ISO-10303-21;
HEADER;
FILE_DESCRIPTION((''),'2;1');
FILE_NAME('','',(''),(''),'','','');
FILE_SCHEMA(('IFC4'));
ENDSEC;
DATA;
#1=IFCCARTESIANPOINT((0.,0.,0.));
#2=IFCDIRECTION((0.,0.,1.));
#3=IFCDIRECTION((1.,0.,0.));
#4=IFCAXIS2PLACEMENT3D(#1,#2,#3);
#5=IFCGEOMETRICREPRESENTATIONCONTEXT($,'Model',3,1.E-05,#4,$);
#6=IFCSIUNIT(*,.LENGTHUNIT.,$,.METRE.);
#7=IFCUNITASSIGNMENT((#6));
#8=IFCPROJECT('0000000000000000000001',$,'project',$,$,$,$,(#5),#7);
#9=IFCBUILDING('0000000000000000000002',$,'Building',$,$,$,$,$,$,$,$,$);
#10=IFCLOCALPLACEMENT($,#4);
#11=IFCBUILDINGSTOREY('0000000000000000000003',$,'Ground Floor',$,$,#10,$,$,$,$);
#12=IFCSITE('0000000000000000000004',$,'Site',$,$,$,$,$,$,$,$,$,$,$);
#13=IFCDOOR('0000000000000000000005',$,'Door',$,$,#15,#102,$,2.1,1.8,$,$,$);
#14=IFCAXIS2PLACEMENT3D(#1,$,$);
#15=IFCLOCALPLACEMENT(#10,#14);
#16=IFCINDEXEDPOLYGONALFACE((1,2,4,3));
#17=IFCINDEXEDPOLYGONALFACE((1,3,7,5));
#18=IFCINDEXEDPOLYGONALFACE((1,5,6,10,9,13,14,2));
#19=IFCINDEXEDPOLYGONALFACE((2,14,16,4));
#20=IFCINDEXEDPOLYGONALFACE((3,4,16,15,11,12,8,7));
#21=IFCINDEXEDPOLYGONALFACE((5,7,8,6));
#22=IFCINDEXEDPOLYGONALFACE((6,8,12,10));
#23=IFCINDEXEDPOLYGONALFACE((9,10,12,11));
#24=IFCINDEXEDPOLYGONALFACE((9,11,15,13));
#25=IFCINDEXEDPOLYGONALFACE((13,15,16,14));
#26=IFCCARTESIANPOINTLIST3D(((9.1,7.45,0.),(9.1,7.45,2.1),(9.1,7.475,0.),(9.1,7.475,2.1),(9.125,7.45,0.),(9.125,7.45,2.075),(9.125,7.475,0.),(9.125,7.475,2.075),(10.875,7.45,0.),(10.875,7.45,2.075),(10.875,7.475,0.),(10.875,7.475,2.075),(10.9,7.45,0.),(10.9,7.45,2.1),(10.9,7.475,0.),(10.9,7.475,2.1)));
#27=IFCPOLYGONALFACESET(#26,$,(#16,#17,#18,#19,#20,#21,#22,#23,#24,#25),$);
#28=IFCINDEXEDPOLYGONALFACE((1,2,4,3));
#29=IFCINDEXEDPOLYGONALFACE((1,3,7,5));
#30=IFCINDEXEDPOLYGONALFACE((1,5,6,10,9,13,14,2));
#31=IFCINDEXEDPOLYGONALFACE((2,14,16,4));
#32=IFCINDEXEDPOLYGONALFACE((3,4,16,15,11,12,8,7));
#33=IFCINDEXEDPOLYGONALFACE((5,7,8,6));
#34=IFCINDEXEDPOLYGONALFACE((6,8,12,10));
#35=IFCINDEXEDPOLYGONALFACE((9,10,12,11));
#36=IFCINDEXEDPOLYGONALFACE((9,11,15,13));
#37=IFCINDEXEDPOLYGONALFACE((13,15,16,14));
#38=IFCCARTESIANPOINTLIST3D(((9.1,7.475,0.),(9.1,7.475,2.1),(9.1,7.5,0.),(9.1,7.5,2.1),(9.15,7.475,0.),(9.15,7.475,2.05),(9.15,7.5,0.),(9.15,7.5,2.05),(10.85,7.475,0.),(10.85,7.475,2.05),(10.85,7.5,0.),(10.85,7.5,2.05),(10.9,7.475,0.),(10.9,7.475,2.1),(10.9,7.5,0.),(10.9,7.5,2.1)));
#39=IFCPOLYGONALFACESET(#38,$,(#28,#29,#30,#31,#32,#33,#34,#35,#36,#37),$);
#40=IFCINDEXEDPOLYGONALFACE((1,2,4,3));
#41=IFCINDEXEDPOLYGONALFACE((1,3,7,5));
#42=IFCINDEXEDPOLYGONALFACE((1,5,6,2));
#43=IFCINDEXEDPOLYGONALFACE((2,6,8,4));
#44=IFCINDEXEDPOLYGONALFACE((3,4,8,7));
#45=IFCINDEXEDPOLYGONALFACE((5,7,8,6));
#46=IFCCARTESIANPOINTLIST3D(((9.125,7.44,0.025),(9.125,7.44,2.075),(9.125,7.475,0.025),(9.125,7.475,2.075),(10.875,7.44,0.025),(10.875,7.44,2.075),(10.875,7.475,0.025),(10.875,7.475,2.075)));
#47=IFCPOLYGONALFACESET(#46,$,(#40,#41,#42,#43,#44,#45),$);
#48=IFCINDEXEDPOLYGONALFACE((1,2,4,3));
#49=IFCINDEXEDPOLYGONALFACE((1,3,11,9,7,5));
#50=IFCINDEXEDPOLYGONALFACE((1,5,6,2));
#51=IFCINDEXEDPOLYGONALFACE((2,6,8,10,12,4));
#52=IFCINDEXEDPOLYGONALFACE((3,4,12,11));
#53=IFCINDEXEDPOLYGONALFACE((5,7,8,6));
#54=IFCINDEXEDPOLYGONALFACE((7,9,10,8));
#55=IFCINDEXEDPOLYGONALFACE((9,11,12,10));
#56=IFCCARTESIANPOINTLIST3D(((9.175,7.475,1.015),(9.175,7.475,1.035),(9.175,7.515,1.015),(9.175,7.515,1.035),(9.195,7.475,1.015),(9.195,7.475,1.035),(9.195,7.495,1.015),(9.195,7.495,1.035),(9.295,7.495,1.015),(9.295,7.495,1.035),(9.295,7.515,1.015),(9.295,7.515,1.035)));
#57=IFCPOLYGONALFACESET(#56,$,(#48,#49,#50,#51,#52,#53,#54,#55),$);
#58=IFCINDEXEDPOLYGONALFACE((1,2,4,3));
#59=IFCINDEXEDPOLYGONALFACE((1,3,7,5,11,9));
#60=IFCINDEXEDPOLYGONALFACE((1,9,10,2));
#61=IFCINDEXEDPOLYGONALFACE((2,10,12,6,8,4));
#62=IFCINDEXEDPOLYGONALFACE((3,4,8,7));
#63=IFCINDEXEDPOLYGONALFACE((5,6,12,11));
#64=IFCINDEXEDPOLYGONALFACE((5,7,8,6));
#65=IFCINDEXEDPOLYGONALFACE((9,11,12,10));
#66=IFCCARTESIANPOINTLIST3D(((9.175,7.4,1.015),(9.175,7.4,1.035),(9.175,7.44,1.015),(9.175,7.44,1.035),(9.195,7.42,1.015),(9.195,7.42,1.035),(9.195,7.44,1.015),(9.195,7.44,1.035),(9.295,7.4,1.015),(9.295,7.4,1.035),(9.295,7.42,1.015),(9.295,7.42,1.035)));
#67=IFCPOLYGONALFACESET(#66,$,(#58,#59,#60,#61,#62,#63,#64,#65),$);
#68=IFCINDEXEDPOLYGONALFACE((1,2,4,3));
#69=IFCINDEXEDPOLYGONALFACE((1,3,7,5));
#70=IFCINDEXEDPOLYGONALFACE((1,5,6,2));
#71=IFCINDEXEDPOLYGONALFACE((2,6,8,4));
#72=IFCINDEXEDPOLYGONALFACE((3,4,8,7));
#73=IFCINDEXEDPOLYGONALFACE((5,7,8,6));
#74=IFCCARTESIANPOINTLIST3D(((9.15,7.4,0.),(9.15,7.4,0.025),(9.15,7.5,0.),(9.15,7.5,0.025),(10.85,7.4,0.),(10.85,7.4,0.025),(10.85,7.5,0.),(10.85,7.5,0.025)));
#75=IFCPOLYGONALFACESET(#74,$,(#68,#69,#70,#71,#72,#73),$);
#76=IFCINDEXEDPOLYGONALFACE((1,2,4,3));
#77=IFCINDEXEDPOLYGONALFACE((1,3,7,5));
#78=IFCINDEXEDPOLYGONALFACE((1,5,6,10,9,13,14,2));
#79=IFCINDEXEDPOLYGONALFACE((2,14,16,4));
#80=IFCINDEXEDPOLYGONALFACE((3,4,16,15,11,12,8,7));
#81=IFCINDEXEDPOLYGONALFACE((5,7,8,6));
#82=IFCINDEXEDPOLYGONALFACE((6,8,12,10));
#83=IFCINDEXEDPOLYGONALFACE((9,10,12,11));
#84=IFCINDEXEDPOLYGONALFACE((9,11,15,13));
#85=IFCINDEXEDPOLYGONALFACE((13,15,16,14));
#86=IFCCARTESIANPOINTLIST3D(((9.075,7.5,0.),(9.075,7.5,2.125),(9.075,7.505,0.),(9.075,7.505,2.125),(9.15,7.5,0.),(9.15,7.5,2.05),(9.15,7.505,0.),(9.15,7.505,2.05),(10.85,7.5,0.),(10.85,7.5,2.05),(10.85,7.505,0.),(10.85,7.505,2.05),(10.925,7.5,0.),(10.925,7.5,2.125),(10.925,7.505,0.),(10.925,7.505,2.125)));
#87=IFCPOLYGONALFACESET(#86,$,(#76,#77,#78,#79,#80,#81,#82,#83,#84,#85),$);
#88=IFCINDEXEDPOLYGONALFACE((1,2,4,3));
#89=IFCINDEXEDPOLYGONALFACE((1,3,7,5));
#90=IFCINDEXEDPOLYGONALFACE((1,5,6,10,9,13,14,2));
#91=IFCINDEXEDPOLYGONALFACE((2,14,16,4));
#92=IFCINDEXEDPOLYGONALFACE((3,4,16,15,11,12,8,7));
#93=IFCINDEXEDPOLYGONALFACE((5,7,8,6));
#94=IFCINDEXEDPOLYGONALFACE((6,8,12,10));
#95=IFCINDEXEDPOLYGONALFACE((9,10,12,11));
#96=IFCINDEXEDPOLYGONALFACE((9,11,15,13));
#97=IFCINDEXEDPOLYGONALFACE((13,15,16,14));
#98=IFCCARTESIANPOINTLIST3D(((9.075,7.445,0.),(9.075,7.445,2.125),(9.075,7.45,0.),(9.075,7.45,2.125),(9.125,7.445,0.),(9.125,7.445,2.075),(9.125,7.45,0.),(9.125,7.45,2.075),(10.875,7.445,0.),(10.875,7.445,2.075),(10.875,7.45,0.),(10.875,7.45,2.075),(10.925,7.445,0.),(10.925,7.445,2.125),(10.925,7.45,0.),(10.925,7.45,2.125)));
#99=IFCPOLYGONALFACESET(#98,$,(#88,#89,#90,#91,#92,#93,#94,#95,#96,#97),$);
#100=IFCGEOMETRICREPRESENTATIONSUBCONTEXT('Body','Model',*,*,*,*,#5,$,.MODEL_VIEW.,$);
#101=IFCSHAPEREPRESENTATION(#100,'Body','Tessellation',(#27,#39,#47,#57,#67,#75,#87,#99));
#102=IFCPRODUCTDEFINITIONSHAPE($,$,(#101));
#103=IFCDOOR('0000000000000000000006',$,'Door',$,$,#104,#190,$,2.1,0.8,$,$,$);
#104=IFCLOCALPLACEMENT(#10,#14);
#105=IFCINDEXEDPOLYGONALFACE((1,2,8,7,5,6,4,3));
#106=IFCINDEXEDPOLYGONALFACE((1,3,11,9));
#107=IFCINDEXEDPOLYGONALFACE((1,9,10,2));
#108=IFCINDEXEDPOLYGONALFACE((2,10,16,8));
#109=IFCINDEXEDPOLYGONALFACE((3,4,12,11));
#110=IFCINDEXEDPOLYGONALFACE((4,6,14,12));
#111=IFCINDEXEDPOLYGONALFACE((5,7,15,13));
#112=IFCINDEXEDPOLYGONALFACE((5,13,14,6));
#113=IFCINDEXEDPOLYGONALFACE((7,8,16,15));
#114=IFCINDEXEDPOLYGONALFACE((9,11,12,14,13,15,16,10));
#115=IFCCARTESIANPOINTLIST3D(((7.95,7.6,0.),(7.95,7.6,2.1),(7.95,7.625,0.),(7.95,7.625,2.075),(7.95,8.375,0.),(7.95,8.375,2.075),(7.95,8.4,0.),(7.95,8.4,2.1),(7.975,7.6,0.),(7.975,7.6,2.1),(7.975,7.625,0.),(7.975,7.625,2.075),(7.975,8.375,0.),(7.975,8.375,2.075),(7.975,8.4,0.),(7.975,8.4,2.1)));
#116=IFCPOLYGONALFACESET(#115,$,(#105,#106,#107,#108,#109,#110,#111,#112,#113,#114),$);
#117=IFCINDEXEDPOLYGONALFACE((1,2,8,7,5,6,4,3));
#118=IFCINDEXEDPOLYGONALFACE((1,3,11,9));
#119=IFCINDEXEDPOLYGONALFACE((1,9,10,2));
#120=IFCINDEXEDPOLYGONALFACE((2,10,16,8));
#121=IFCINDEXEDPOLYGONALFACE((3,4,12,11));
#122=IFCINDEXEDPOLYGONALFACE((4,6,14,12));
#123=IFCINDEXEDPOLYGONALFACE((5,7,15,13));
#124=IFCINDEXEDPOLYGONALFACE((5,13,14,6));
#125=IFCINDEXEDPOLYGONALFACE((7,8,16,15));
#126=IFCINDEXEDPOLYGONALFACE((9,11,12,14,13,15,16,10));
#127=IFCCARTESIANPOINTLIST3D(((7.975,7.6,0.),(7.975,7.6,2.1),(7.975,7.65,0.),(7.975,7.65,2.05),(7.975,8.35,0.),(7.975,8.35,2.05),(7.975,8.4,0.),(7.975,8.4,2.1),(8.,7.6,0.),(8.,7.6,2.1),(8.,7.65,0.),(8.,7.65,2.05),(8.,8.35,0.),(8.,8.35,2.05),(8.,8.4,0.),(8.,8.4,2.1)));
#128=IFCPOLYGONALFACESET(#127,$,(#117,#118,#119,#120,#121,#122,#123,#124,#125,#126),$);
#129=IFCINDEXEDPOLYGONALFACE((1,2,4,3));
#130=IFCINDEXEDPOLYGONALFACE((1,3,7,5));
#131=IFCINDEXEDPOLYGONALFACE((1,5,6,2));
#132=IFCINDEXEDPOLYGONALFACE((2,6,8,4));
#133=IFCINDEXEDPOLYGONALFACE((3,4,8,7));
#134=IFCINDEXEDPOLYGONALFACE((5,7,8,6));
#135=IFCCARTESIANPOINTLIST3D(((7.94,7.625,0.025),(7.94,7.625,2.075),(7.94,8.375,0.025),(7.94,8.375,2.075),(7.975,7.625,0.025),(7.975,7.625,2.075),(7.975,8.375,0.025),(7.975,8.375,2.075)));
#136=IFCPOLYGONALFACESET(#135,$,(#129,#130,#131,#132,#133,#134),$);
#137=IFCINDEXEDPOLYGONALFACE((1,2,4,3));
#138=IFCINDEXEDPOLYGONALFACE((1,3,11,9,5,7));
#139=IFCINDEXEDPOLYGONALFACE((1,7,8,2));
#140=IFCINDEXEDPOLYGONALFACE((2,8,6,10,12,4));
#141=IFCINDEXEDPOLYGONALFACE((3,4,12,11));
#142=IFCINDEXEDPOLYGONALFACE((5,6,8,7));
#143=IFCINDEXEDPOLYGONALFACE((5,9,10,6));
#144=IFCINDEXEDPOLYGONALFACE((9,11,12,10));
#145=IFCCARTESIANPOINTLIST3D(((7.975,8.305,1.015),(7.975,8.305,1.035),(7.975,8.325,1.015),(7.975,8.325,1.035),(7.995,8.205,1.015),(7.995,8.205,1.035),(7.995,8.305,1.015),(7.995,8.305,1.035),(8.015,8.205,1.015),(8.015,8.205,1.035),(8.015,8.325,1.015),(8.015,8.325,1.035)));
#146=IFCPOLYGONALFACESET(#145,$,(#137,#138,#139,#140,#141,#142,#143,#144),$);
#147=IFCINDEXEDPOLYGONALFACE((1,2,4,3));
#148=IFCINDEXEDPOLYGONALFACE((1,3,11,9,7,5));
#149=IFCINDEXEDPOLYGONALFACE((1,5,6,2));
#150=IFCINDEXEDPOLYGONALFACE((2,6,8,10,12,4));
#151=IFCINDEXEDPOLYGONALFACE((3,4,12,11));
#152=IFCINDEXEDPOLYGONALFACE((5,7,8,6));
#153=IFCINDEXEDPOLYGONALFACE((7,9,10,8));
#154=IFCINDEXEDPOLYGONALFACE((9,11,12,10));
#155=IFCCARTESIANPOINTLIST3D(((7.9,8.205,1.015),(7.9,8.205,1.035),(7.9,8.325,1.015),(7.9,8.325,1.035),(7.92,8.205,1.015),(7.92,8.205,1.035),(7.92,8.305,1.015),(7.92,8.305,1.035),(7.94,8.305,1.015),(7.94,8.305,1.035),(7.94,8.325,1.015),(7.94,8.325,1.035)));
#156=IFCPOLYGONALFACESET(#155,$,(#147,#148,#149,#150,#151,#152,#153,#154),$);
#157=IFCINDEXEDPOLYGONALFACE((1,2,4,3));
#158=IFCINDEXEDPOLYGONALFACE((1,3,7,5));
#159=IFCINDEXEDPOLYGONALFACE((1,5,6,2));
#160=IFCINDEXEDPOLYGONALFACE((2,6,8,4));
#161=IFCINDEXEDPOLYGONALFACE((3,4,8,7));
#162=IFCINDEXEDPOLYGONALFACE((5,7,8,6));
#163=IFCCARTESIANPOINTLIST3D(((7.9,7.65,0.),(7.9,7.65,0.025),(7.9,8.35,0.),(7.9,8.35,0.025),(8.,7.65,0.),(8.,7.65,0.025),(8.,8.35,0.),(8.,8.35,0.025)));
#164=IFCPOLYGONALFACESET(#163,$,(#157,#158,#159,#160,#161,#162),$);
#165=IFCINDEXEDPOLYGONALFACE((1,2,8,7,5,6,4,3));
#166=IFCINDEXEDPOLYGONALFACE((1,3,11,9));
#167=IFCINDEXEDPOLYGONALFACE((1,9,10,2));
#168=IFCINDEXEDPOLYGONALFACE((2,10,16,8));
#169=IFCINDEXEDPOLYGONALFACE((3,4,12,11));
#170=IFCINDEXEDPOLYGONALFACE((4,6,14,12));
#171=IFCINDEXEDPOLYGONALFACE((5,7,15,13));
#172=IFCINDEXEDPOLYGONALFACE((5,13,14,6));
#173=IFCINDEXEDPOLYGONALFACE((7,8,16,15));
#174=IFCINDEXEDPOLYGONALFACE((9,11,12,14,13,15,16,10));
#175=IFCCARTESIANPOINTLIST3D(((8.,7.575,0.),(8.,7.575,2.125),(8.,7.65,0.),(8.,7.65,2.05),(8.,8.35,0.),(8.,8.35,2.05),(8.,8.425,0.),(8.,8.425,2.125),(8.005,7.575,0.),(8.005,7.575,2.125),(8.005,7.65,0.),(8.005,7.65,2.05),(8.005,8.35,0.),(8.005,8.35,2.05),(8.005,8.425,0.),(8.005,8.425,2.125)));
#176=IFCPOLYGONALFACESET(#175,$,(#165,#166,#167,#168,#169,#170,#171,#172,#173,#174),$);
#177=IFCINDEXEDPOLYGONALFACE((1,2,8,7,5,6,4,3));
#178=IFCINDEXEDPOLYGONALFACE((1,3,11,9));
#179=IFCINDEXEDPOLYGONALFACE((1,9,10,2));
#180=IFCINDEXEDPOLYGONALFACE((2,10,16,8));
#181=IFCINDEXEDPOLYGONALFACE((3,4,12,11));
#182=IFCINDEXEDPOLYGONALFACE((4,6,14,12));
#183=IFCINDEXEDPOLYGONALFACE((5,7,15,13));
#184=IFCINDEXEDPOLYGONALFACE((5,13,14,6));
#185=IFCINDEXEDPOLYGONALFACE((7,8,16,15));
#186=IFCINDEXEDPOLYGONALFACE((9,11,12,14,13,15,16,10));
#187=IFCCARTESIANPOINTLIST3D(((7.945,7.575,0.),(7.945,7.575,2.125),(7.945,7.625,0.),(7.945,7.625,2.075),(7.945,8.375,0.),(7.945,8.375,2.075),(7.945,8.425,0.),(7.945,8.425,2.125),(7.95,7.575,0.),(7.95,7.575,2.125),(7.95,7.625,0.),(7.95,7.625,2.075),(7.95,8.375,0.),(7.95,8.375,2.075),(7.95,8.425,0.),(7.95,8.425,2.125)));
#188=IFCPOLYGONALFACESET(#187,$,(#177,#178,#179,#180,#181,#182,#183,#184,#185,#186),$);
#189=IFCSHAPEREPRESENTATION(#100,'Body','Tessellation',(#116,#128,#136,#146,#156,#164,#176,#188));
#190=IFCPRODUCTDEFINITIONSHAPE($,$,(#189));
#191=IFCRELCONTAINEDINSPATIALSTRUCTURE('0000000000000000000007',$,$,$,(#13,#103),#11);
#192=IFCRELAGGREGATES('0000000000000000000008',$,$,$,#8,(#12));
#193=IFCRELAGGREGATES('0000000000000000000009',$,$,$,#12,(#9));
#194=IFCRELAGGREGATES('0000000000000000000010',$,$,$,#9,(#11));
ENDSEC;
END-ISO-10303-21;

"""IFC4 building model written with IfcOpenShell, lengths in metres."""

from ifc_helpers import new_model, si_unit, frame, origin_with_axes, place, context, subcontext, project, spatial, line, indexed_curve, outline, extrude, element, save


model = new_model("IFC4")

# Units and contexts
model_context = context("Model", 3, precision=1e-05, world=origin_with_axes())
body_context = subcontext(model_context, "Body", "Model", "MODEL_VIEW")
ifc_project = project(units=[si_unit("LENGTHUNIT", "METRE")], contexts=[model_context])

# Site, building, storey
site = spatial("IfcSite", under=ifc_project, Name="Site")
building = spatial("IfcBuilding", under=site, Name="Building")
storey_placement = place(None, origin_with_axes())
storey = spatial("IfcBuildingStorey", under=building, at=storey_placement, Name="Ground Floor")

# Doors
door_1_placement = place(storey_placement, frame((10.9, 7.5, 0.0), z_axis=(0.0, 0.0, 1.0), x_axis=(-1.0, 0.0, 0.0)))
element("IfcDoor", 1, at=door_1_placement, inside=storey, Name="Door", OverallHeight=2.1, OverallWidth=1.8, context=body_context, shape_type="SweptSolid", body=[
    extrude(outline(indexed_curve([(0.0, 0.0), (0.0, 2.1), (1.8, 2.1), (1.8, 0.0), (1.775, 0.0), (1.775, 2.075), (0.025, 2.075), (0.025, 0.0)], segments=[line(1, 2, 3, 4, 5, 6, 7, 8, 1)])), frame((0.0, 0.025, 0.0), z_axis=(0.0, -1.0, 0.0), x_axis=(1.0, 0.0, 0.0)), (0.0, 0.0, -1.0), 0.025),
    extrude(outline(indexed_curve([(0.0, 0.0), (0.0, 2.1), (1.8, 2.1), (1.8, 0.0), (1.75, 0.0), (1.75, 2.05), (0.05, 2.05), (0.05, 0.0)], segments=[line(1, 2, 3, 4, 5, 6, 7, 8, 1)])), frame((0.0, 0.0, 0.0), z_axis=(0.0, -1.0, 0.0), x_axis=(1.0, 0.0, 0.0)), (0.0, 0.0, -1.0), 0.025),
    extrude(outline(indexed_curve([(0.0, 0.0), (1.75, 0.0), (1.75, 0.035), (0.0, 0.035)], segments=[line(1, 2, 3, 4, 1)])), frame((0.025, 0.025, 0.025), z_axis=(0.0, 0.0, 1.0), x_axis=(1.0, 0.0, 0.0)), (0.0, 0.0, 1.0), 2.05),
    extrude(outline(indexed_curve([(0.0, 0.0), (0.0, -0.04), (-0.12, -0.04), (-0.12, -0.02), (-0.02, -0.02), (-0.02, 0.0)], segments=[line(1, 2, 3, 4, 5, 6, 1)])), frame((1.725, 0.025, 1.015), z_axis=(0.0, 0.0, 1.0), x_axis=(1.0, 0.0, 0.0)), (0.0, 0.0, 1.0), 0.02),
    extrude(outline(indexed_curve([(0.0, 0.0), (0.0, 0.04), (-0.12, 0.04), (-0.12, 0.02), (-0.02, 0.02), (-0.02, 0.0)], segments=[line(1, 2, 3, 4, 5, 6, 1)])), frame((1.725, 0.06, 1.015), z_axis=(0.0, 0.0, 1.0), x_axis=(1.0, 0.0, 0.0)), (0.0, 0.0, 1.0), 0.02),
    extrude(outline(indexed_curve([(0.0, 0.0), (1.7, 0.0), (1.7, 0.1), (0.0, 0.1)], segments=[line(1, 2, 3, 4, 1)])), frame((0.05, 0.0, 0.0), z_axis=(0.0, 0.0, 1.0), x_axis=(1.0, 0.0, 0.0)), (0.0, 0.0, 1.0), 0.025),
    extrude(outline(indexed_curve([(0.0, 0.0), (0.0, 2.125), (1.85, 2.125), (1.85, 0.0), (1.775, 0.0), (1.775, 2.05), (0.075, 2.05), (0.075, 0.0)], segments=[line(1, 2, 3, 4, 5, 6, 7, 8, 1)])), frame((-0.025, -0.005, 0.0), z_axis=(0.0, -1.0, 0.0), x_axis=(1.0, 0.0, 0.0)), (0.0, 0.0, -1.0), 0.005),
    extrude(outline(indexed_curve([(0.0, 0.0), (0.0, 2.125), (1.85, 2.125), (1.85, 0.0), (1.8, 0.0), (1.8, 2.075), (0.05, 2.075), (0.05, 0.0)], segments=[line(1, 2, 3, 4, 5, 6, 7, 8, 1)])), frame((-0.025, 0.05, 0.0), z_axis=(0.0, -1.0, 0.0), x_axis=(1.0, 0.0, 0.0)), (0.0, 0.0, -1.0), 0.005),
])
door_2_placement = place(storey_placement, frame((8.0, 7.6, 0.0), z_axis=(0.0, 0.0, 1.0), x_axis=(0.0, 1.0, 0.0)))
element("IfcDoor", 2, at=door_2_placement, inside=storey, Name="Door", OverallHeight=2.1, OverallWidth=0.8, context=body_context, shape_type="SweptSolid", body=[
    extrude(outline(indexed_curve([(0.0, 0.0), (0.0, 2.1), (0.8, 2.1), (0.8, 0.0), (0.775, 0.0), (0.775, 2.075), (0.025, 2.075), (0.025, 0.0)], segments=[line(1, 2, 3, 4, 5, 6, 7, 8, 1)])), frame((0.0, 0.025, 0.0), z_axis=(0.0, -1.0, 0.0), x_axis=(1.0, 0.0, 0.0)), (0.0, 0.0, -1.0), 0.025),
    extrude(outline(indexed_curve([(0.0, 0.0), (0.0, 2.1), (0.8, 2.1), (0.8, 0.0), (0.75, 0.0), (0.75, 2.05), (0.05, 2.05), (0.05, 0.0)], segments=[line(1, 2, 3, 4, 5, 6, 7, 8, 1)])), frame((0.0, 0.0, 0.0), z_axis=(0.0, -1.0, 0.0), x_axis=(1.0, 0.0, 0.0)), (0.0, 0.0, -1.0), 0.025),
    extrude(outline(indexed_curve([(0.0, 0.0), (0.75, 0.0), (0.75, 0.035), (0.0, 0.035)], segments=[line(1, 2, 3, 4, 1)])), frame((0.025, 0.025, 0.025), z_axis=(0.0, 0.0, 1.0), x_axis=(1.0, 0.0, 0.0)), (0.0, 0.0, 1.0), 2.05),
    extrude(outline(indexed_curve([(0.0, 0.0), (0.0, -0.04), (-0.12, -0.04), (-0.12, -0.02), (-0.02, -0.02), (-0.02, 0.0)], segments=[line(1, 2, 3, 4, 5, 6, 1)])), frame((0.725, 0.025, 1.015), z_axis=(0.0, 0.0, 1.0), x_axis=(1.0, 0.0, 0.0)), (0.0, 0.0, 1.0), 0.02),
    extrude(outline(indexed_curve([(0.0, 0.0), (0.0, 0.04), (-0.12, 0.04), (-0.12, 0.02), (-0.02, 0.02), (-0.02, 0.0)], segments=[line(1, 2, 3, 4, 5, 6, 1)])), frame((0.725, 0.06, 1.015), z_axis=(0.0, 0.0, 1.0), x_axis=(1.0, 0.0, 0.0)), (0.0, 0.0, 1.0), 0.02),
    extrude(outline(indexed_curve([(0.0, 0.0), (0.7, 0.0), (0.7, 0.1), (0.0, 0.1)], segments=[line(1, 2, 3, 4, 1)])), frame((0.05, 0.0, 0.0), z_axis=(0.0, 0.0, 1.0), x_axis=(1.0, 0.0, 0.0)), (0.0, 0.0, 1.0), 0.025),
    extrude(outline(indexed_curve([(0.0, 0.0), (0.0, 2.125), (0.85, 2.125), (0.85, 0.0), (0.775, 0.0), (0.775, 2.05), (0.075, 2.05), (0.075, 0.0)], segments=[line(1, 2, 3, 4, 5, 6, 7, 8, 1)])), frame((-0.025, -0.005, 0.0), z_axis=(0.0, -1.0, 0.0), x_axis=(1.0, 0.0, 0.0)), (0.0, 0.0, -1.0), 0.005),
    extrude(outline(indexed_curve([(0.0, 0.0), (0.0, 2.125), (0.85, 2.125), (0.85, 0.0), (0.8, 0.0), (0.8, 2.075), (0.05, 2.075), (0.05, 0.0)], segments=[line(1, 2, 3, 4, 5, 6, 7, 8, 1)])), frame((-0.025, 0.05, 0.0), z_axis=(0.0, -1.0, 0.0), x_axis=(1.0, 0.0, 0.0)), (0.0, 0.0, -1.0), 0.005),
])

save(model, "model.ifc")
